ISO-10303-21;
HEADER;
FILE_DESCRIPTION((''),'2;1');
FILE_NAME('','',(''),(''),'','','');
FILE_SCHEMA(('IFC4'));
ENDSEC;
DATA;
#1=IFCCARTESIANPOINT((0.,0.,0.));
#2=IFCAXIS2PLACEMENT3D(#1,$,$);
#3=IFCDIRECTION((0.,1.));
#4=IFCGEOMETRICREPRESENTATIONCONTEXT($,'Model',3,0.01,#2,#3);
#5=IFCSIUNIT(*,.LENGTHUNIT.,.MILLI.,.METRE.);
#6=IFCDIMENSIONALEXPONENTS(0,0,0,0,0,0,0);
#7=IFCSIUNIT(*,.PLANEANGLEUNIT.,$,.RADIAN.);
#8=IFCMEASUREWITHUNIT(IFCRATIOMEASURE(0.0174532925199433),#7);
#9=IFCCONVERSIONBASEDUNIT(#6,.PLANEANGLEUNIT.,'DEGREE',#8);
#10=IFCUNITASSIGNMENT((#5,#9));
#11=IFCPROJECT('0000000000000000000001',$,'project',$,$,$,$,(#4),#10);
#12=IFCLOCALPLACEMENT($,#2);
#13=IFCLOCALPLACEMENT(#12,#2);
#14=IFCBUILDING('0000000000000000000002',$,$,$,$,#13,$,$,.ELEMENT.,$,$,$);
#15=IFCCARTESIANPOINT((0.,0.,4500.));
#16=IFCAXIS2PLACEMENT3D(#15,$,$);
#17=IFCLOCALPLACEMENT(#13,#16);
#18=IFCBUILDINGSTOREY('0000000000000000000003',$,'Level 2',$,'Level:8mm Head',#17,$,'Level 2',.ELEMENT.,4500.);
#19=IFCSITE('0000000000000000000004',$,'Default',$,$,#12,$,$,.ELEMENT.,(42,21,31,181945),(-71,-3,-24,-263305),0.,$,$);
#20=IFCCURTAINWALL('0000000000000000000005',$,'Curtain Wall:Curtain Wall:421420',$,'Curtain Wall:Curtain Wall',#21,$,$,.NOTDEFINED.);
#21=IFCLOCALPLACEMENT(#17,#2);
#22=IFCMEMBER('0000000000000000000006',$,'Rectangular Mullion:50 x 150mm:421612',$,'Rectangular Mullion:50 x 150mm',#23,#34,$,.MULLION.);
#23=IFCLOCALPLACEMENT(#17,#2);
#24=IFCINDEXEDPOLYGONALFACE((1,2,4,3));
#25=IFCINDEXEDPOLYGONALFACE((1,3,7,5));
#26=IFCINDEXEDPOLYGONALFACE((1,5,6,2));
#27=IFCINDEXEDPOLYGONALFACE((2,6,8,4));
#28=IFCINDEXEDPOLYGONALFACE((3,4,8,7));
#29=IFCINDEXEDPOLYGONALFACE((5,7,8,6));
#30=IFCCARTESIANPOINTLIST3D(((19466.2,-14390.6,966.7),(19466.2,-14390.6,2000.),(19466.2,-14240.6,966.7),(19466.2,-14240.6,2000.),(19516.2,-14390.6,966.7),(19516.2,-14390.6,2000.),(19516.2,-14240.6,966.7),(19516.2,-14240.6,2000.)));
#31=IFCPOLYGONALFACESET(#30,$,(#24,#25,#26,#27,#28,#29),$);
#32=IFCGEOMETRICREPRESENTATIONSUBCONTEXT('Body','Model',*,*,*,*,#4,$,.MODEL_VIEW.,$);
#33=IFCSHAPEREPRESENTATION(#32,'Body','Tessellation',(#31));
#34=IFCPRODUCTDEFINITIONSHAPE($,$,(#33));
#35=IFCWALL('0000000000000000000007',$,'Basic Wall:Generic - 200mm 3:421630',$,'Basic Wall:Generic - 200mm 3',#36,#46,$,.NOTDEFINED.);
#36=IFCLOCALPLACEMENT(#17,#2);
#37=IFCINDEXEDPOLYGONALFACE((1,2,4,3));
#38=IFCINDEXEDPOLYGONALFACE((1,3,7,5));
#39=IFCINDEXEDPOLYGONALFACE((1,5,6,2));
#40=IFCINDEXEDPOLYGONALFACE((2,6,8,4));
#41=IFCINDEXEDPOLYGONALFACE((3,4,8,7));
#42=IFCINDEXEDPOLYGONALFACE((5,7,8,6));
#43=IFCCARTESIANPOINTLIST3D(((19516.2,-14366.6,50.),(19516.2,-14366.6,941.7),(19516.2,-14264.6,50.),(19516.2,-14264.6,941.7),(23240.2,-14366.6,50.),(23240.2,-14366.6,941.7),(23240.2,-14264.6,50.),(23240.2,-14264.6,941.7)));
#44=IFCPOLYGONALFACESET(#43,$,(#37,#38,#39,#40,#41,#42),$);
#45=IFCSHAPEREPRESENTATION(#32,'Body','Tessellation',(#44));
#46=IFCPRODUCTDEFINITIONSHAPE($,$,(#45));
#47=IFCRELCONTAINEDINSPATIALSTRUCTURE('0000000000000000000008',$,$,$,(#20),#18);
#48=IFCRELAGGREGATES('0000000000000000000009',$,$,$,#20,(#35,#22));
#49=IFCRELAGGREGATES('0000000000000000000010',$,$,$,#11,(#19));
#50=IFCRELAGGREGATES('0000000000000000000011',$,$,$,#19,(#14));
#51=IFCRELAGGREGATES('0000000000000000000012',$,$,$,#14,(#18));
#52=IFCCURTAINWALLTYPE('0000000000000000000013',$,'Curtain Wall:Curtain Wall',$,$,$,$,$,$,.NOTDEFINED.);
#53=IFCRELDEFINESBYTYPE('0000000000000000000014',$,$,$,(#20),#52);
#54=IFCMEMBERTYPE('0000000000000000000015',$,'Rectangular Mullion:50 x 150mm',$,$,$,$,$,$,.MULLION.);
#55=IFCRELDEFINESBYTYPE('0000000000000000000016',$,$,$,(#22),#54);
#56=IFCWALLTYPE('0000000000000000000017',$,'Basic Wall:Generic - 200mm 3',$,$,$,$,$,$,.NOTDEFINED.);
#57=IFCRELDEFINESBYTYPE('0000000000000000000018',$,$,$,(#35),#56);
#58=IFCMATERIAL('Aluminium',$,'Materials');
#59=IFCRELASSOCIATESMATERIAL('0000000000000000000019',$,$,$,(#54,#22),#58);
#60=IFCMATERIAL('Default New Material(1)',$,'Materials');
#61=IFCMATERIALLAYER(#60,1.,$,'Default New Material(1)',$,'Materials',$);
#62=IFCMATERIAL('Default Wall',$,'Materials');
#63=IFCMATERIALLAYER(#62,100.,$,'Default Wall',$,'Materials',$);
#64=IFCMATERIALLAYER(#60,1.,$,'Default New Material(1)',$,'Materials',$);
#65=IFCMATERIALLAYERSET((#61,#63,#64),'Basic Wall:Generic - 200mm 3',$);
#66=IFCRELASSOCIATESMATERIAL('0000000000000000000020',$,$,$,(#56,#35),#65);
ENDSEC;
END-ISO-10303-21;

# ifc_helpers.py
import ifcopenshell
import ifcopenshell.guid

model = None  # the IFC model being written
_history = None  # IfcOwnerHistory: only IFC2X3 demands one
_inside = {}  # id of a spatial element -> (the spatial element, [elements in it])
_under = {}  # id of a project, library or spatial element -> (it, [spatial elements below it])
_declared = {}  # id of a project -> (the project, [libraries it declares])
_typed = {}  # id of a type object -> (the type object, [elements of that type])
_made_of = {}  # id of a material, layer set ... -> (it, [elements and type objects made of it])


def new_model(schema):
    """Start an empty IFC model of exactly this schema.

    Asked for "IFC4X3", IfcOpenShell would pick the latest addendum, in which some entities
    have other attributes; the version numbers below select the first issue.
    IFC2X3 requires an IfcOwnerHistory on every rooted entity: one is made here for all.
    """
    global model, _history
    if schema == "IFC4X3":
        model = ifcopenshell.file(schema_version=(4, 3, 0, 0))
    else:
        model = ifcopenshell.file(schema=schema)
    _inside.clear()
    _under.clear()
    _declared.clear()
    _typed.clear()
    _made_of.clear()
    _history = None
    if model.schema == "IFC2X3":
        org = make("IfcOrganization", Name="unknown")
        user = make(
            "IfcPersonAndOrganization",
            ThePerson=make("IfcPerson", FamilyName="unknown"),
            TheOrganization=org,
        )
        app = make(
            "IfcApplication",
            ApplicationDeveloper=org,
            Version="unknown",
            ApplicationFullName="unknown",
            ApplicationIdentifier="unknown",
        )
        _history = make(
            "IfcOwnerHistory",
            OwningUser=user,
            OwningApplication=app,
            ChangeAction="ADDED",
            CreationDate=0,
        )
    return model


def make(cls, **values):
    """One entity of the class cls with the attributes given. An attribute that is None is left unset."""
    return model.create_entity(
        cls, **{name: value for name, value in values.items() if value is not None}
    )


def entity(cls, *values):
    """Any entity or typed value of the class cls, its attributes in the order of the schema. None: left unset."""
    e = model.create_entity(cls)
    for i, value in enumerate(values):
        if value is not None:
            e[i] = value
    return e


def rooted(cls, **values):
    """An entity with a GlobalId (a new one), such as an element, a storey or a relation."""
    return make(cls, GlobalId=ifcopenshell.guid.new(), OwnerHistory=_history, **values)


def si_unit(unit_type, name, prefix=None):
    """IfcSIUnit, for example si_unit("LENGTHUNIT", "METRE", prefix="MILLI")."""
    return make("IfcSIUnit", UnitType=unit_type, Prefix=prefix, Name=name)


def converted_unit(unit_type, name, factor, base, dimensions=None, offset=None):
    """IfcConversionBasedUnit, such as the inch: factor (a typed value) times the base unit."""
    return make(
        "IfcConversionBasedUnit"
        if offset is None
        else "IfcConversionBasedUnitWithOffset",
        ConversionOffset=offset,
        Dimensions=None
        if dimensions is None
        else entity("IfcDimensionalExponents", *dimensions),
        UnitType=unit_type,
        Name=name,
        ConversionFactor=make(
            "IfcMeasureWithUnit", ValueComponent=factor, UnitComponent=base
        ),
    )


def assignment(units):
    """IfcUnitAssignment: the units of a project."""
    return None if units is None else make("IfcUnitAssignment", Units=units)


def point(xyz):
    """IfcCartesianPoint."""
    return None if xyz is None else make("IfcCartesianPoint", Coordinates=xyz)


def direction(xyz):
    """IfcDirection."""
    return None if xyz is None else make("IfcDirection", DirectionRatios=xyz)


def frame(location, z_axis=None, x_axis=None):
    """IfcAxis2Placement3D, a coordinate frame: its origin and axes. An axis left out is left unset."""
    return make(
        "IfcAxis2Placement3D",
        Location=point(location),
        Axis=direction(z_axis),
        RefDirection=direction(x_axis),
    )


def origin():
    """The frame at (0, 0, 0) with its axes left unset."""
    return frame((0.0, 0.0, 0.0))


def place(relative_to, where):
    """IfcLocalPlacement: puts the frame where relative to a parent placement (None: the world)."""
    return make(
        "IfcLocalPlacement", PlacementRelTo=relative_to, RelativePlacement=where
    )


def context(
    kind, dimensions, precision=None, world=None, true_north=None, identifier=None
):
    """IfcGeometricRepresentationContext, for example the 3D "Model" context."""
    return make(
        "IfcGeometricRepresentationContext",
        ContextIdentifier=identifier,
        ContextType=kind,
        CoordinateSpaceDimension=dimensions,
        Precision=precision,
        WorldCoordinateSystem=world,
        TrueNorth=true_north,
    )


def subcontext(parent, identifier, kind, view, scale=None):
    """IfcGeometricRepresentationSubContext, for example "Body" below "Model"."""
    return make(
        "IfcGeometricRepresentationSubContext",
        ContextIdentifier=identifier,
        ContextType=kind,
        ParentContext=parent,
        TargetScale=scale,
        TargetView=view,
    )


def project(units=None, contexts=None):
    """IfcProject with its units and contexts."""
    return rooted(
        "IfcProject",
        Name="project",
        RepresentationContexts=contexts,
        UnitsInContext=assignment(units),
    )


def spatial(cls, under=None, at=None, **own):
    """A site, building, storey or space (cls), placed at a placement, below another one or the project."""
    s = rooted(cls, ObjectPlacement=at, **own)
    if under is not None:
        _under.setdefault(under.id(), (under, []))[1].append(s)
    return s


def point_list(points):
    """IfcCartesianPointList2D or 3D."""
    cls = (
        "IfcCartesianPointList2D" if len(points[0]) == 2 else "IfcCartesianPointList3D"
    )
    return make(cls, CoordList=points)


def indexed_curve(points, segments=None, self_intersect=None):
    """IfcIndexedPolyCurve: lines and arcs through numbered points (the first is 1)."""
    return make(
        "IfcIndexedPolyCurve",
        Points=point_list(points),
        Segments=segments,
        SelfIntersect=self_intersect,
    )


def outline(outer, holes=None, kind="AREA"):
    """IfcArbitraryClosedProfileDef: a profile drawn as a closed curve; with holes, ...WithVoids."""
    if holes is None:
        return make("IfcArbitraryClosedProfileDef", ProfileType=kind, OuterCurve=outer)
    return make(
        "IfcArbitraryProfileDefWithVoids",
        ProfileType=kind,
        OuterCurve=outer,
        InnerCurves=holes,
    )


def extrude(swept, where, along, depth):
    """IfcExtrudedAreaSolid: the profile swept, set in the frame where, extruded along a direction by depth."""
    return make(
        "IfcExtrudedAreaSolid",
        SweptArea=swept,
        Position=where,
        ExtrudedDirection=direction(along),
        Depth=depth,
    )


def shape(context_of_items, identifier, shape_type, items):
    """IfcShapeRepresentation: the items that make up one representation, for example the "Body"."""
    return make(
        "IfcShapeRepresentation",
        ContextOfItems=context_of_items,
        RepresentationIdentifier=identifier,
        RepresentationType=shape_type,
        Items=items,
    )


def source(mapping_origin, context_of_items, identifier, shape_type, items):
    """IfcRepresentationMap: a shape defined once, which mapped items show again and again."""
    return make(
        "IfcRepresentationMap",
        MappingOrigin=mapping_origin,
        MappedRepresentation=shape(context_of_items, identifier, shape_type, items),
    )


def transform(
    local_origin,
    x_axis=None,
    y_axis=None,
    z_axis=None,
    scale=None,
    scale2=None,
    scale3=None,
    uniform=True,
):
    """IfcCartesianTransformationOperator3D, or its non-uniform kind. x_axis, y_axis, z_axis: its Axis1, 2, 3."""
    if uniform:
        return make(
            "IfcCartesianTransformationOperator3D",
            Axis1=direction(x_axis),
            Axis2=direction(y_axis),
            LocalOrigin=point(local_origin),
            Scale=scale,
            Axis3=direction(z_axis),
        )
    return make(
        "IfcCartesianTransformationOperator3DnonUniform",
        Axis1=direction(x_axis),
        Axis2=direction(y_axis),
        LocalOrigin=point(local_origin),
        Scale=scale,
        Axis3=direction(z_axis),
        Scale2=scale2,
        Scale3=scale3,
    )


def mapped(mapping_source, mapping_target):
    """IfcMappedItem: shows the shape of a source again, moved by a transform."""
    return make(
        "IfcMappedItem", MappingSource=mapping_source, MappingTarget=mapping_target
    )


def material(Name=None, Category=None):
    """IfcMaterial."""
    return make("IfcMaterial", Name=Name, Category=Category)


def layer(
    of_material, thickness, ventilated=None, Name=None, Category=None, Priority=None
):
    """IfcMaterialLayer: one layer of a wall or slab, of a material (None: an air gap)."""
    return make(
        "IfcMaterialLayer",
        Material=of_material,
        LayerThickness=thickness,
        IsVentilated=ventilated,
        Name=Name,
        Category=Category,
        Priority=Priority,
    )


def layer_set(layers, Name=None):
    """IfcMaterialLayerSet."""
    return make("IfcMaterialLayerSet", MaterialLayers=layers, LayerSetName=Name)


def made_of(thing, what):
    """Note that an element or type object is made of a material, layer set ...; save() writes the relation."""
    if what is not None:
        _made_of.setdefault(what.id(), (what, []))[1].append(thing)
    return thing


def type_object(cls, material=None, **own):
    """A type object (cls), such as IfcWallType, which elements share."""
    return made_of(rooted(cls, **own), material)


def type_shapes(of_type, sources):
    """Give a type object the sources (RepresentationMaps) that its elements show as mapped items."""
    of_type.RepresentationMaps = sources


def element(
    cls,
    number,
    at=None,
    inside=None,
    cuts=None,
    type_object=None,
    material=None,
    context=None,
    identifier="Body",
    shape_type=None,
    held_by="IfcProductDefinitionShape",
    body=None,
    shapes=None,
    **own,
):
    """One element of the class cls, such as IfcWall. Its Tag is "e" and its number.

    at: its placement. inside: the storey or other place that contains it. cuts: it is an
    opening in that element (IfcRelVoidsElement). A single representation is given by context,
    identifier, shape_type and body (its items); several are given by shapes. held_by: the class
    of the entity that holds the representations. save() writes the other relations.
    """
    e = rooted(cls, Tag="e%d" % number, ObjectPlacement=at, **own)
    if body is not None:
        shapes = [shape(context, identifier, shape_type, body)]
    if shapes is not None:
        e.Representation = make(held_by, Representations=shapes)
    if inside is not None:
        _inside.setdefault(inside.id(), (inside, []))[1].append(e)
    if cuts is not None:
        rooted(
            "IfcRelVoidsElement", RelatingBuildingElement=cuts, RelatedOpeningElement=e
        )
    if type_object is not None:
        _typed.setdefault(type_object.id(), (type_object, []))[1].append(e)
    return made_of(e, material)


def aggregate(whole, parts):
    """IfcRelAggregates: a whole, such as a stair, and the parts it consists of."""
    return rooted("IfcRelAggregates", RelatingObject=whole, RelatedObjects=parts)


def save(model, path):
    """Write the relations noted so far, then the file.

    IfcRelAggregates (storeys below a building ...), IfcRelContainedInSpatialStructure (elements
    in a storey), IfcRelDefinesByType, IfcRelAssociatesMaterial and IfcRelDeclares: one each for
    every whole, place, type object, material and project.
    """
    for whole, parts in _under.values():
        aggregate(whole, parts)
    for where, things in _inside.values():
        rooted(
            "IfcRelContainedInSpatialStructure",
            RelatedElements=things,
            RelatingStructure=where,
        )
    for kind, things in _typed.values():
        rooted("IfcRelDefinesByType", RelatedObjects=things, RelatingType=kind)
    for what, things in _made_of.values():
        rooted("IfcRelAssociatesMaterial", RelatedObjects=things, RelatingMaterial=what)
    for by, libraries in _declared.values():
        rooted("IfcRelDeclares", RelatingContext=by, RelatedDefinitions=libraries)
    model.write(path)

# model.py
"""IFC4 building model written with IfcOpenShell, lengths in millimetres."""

from ifc_helpers import new_model, entity, si_unit, converted_unit, direction, frame, origin, place, context, subcontext, project, spatial, indexed_curve, outline, extrude, source, transform, mapped, material, layer, layer_set, type_object, type_shapes, element, aggregate, save


model = new_model("IFC4")

# Units and contexts
model_context = context("Model", 3, precision=0.01, world=origin(), true_north=direction((0.0, 1.0)))
body_context = subcontext(model_context, "Body", "Model", "MODEL_VIEW")
ifc_project = project(units=[si_unit("LENGTHUNIT", "METRE", prefix="MILLI"), converted_unit("PLANEANGLEUNIT", "DEGREE", entity("IfcRatioMeasure", 0.0174532925199433), si_unit("PLANEANGLEUNIT", "RADIAN"), dimensions=[0, 0, 0, 0, 0, 0, 0])], contexts=[model_context])

# Site, building, storey
site_placement = place(None, origin())
site = spatial("IfcSite", under=ifc_project, at=site_placement, Name="Default", CompositionType="ELEMENT", RefLatitude=(42, 21, 31, 181945), RefLongitude=(-71, -3, -24, -263305), RefElevation=0.0)
building_placement = place(site_placement, origin())
building = spatial("IfcBuilding", under=site, at=building_placement, CompositionType="ELEMENT")
storey_placement = place(building_placement, frame((0.0, 0.0, 4500.0)))
storey = spatial("IfcBuildingStorey", under=building, at=storey_placement, Name="Level 2", ObjectType="Level:8mm Head", LongName="Level 2", CompositionType="ELEMENT", Elevation=4500.0)

# Shared definitions
ifc_material_1 = material(Name="Aluminium", Category="Materials")

# Curtain wall, member
curtain_wall_type_1 = type_object("IfcCurtainWallType", Name="Curtain Wall:Curtain Wall", PredefinedType="NOTDEFINED")
curtain_wall_1_placement = place(storey_placement, frame((0.0, 0.0, -4500.0)))
curtain_wall_1 = element("IfcCurtainWall", 1, at=curtain_wall_1_placement, inside=storey, type_object=curtain_wall_type_1, Name="Curtain Wall:Curtain Wall:421420", ObjectType="Curtain Wall:Curtain Wall", PredefinedType="NOTDEFINED")
member_type_1 = type_object("IfcMemberType", Name="Rectangular Mullion:50 x 150mm", PredefinedType="MULLION", material=ifc_material_1)
shared_shape_1 = source(origin(), body_context, "Body", "SweptSolid", [
    extrude(outline(indexed_curve([(-75.0, -25.0), (75.0, -25.0), (75.0, 25.0), (-75.0, 25.0), (-75.0, -25.0)], self_intersect=False)), frame((-25.0, 0.0, -1033.3), z_axis=(0.0, 0.0, 1.0), x_axis=(0.0, -1.0, 0.0)), (0.0, 0.0, 1.0), 1033.3),
])
type_shapes(member_type_1, [shared_shape_1])
member_1_placement = place(storey_placement, frame((19466.2, -14315.6, 2000.0), z_axis=(0.0, 0.0, 1.0), x_axis=(-1.0, 0.0, 0.0)))
member_1 = element("IfcMember", 2, at=member_1_placement, type_object=member_type_1, material=ifc_material_1, Name="Rectangular Mullion:50 x 150mm:421612", ObjectType="Rectangular Mullion:50 x 150mm", PredefinedType="MULLION", context=body_context, shape_type="MappedRepresentation", body=[
    mapped(shared_shape_1, transform((0.0, 0.0, 0.0), scale=1.0)),
])

# Wall
ifc_material_2 = material(Name="Default New Material(1)", Category="Materials")
ifc_layer_1 = layer(ifc_material_2, 1.0, Name="Default New Material(1)", Category="Materials")
ifc_material_3 = material(Name="Default Wall", Category="Materials")
ifc_layer_2 = layer(ifc_material_3, 100.0, Name="Default Wall", Category="Materials")
ifc_layer_3 = layer(ifc_material_2, 1.0, Name="Default New Material(1)", Category="Materials")
ifc_layer_set = layer_set([ifc_layer_1, ifc_layer_2, ifc_layer_3], Name="Basic Wall:Generic - 200mm 3")
wall_type = type_object("IfcWallType", Name="Basic Wall:Generic - 200mm 3", PredefinedType="NOTDEFINED", material=ifc_layer_set)
wall_placement = place(storey_placement, frame((19516.2, -14315.6, 50.0)))
wall = element("IfcWall", 3, at=wall_placement, type_object=wall_type, material=ifc_layer_set, Name="Basic Wall:Generic - 200mm 3:421630", ObjectType="Basic Wall:Generic - 200mm 3", PredefinedType="NOTDEFINED", context=body_context, shape_type="SweptSolid", body=[
    extrude(outline(indexed_curve([(3724.0, 51.0), (0.0, 51.0), (0.0, -51.0), (3724.0, -51.0), (3724.0, 51.0)], self_intersect=False)), origin(), (0.0, 0.0, 1.0), 891.7),
])
aggregate(curtain_wall_1, [wall, member_1])

save(model, "model.ifc")
